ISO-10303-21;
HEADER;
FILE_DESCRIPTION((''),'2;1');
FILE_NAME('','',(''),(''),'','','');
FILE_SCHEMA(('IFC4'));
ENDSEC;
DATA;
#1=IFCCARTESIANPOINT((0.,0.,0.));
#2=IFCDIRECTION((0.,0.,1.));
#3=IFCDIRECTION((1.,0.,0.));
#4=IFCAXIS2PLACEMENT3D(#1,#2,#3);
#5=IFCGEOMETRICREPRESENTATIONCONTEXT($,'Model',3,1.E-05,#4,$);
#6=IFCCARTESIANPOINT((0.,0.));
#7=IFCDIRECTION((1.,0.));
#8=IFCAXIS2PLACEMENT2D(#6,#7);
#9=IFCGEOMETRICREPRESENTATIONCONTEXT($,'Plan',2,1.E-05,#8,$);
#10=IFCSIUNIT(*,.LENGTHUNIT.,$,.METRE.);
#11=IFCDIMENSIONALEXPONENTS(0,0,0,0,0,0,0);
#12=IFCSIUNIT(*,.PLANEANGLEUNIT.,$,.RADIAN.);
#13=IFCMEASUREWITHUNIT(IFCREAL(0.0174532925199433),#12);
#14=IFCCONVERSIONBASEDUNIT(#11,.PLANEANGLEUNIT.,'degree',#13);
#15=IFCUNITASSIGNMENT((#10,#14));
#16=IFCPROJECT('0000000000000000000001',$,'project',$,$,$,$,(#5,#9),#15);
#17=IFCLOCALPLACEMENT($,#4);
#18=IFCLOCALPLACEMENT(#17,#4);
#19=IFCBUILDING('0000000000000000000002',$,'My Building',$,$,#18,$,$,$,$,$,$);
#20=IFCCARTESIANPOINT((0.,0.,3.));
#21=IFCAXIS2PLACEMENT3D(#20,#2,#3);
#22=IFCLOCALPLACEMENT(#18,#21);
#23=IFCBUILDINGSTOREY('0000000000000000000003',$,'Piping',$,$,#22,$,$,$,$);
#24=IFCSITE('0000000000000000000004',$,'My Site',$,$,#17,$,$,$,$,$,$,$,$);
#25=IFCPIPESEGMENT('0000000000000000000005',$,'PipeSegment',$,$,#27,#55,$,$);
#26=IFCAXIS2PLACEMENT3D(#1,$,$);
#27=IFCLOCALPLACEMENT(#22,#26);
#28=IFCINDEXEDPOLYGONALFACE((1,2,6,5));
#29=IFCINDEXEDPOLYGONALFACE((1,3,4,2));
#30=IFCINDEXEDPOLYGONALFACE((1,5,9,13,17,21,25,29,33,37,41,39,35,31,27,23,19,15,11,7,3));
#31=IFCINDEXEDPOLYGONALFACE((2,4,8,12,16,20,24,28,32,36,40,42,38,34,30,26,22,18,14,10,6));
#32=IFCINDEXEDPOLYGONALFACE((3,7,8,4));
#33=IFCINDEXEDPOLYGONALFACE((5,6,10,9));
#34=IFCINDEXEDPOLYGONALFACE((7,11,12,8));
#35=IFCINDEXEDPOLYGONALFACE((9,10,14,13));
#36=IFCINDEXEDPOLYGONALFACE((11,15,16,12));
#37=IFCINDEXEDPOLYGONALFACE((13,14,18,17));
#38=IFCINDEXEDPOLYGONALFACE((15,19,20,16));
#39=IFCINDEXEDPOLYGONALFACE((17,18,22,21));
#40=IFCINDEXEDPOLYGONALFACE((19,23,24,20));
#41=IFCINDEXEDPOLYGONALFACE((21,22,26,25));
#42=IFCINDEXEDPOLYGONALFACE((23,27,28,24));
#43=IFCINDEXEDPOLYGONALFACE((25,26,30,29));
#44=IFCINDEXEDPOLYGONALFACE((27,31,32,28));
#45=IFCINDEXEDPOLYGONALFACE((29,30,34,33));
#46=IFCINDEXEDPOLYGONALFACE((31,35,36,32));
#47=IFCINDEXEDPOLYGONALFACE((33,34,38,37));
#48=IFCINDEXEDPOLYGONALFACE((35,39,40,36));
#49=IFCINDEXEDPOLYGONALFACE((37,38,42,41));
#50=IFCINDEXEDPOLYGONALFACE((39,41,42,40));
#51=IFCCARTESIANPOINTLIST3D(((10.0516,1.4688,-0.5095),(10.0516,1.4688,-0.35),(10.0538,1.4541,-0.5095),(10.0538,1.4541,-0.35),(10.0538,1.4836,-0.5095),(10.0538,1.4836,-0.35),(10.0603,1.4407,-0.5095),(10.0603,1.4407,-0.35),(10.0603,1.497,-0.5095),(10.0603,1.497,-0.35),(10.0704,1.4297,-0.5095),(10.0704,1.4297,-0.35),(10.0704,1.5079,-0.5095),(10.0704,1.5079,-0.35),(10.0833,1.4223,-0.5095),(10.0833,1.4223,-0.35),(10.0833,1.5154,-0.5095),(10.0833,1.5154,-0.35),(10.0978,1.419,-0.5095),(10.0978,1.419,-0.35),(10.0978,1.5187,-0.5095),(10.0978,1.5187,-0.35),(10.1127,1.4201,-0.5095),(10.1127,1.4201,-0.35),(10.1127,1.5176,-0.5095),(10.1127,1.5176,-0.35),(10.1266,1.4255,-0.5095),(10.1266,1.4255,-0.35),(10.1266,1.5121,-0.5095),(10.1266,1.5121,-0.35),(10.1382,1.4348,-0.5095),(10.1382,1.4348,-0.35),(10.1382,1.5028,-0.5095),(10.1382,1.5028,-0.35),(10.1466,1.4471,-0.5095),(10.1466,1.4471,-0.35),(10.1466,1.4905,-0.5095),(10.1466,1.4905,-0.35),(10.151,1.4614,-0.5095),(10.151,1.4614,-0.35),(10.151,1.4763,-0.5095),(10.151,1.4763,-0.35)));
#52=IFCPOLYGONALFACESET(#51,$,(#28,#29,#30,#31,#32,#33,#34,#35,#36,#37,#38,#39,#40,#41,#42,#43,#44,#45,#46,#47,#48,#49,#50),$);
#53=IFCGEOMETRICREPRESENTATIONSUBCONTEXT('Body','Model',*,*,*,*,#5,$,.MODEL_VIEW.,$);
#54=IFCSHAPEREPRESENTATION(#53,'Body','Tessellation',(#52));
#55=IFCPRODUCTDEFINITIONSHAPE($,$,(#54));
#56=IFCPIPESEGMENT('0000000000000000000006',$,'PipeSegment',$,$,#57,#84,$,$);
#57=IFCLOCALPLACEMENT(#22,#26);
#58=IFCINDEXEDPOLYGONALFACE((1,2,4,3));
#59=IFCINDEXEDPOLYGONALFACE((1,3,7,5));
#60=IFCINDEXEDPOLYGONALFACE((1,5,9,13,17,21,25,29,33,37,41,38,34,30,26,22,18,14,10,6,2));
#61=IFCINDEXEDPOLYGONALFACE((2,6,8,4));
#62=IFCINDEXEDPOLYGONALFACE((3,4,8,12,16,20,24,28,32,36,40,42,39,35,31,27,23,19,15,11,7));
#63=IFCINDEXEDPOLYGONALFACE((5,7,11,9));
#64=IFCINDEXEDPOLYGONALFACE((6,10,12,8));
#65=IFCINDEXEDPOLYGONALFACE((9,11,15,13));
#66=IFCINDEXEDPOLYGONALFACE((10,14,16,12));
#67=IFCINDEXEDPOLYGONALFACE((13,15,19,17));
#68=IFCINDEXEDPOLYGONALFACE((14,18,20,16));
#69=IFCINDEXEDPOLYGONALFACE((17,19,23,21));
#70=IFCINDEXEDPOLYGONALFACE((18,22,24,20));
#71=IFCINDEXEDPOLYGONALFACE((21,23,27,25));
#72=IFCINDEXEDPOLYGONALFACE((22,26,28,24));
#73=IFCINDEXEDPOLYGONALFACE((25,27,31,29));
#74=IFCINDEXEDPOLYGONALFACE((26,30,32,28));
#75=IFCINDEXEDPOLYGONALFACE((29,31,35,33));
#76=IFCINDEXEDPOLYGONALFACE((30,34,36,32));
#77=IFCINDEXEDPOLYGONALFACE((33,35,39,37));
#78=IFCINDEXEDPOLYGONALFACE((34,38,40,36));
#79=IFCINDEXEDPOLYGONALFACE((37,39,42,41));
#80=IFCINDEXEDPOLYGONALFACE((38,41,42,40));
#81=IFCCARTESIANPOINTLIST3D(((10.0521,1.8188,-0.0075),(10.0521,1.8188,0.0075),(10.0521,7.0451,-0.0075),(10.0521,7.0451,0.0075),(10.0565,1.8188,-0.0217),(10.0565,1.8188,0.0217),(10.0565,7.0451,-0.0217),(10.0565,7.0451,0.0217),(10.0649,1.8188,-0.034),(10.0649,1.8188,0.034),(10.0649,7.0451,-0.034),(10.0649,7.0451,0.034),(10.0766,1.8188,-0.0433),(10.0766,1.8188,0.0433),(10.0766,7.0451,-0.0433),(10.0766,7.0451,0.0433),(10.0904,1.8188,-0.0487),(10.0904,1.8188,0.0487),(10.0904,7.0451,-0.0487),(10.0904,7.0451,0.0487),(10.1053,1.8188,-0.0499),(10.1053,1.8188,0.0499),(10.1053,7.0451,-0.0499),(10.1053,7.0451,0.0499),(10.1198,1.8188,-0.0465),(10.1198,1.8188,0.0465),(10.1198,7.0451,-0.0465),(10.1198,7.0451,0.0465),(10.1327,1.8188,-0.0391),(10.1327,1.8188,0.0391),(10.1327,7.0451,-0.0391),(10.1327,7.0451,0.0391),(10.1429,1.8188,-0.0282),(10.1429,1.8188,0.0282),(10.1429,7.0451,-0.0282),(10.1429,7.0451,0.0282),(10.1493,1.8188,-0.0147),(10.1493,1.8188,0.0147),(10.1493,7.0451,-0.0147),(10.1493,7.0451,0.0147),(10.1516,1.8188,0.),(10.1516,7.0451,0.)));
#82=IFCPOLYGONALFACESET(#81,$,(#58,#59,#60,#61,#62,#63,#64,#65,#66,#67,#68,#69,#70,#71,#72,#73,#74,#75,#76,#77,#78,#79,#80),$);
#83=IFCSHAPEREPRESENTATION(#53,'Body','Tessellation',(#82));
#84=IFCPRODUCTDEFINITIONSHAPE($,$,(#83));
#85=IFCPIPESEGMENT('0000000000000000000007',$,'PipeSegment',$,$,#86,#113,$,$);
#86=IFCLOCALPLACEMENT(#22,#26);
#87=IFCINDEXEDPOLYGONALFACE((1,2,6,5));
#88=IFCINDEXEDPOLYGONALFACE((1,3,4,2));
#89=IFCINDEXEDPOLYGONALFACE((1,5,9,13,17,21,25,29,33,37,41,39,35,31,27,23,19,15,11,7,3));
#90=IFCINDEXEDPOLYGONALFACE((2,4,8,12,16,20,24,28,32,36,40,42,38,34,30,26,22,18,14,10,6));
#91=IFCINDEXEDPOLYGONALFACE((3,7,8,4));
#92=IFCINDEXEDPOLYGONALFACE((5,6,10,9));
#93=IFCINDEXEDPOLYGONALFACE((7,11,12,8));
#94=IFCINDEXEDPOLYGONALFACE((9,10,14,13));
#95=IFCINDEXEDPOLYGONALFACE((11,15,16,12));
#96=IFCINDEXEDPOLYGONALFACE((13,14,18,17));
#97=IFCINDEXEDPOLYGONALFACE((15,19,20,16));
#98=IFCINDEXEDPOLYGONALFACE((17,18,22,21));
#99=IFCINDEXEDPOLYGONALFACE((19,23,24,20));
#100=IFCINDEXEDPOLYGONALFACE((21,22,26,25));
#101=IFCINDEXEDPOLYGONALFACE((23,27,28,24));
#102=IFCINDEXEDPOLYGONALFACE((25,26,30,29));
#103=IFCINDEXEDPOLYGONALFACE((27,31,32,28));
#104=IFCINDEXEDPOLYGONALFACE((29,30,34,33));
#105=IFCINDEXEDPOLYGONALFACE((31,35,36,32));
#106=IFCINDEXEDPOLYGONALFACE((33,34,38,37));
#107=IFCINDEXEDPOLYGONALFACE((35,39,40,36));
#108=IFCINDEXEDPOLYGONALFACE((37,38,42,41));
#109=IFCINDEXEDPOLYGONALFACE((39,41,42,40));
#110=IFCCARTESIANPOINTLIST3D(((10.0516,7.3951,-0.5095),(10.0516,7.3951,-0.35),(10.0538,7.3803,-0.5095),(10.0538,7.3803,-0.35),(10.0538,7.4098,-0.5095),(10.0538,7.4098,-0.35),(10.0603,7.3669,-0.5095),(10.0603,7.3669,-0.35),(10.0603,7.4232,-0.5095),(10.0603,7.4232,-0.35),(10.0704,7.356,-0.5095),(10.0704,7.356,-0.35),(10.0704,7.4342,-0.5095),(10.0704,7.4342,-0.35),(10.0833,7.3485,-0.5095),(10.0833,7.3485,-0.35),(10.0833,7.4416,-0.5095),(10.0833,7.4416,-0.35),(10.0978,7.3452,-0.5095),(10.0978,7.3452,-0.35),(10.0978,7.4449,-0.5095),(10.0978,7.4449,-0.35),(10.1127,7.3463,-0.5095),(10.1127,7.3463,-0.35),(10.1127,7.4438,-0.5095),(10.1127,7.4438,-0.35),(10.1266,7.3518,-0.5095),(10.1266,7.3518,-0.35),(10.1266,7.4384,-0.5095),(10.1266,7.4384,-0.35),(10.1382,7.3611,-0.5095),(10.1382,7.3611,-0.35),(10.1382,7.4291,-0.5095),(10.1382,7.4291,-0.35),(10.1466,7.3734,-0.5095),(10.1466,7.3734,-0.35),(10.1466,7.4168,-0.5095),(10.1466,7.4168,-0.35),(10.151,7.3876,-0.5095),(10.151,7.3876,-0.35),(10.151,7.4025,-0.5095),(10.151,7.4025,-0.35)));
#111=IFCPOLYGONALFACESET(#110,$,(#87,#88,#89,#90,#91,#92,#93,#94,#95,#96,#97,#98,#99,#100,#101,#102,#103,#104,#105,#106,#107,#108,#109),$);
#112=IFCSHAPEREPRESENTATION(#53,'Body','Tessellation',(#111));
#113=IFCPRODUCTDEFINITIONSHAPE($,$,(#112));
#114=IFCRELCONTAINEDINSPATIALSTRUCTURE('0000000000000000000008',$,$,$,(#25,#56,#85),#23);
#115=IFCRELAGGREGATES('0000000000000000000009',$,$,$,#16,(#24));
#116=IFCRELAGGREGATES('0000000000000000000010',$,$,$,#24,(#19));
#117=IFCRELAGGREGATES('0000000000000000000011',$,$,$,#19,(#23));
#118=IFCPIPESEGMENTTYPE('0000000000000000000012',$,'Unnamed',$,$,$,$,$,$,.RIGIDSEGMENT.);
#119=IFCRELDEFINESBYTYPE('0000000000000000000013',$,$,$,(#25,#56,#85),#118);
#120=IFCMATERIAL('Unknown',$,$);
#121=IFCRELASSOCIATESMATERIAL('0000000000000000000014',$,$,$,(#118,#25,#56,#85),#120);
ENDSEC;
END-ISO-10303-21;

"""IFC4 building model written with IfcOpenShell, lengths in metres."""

from ifc_helpers import new_model, entity, si_unit, converted_unit, frame, origin_with_axes, origin_2d_with_axis, place, context, subcontext, project, spatial, circle, extrude, material, material_profile, profile_set, profile_usage, type_object, element, save


model = new_model("IFC4")

# Units and contexts
model_context = context("Model", 3, precision=1e-05, world=origin_with_axes())
plan_context = context("Plan", 2, precision=1e-05, world=origin_2d_with_axis())
body_context = subcontext(model_context, "Body", "Model", "MODEL_VIEW")
ifc_project = project(units=[si_unit("LENGTHUNIT", "METRE"), converted_unit("PLANEANGLEUNIT", "degree", entity("IfcReal", 0.0174532925199433), si_unit("PLANEANGLEUNIT", "RADIAN"), dimensions=[0, 0, 0, 0, 0, 0, 0])], contexts=[model_context, plan_context])

# Site, building, storey
site_placement = place(None, origin_with_axes())
site = spatial("IfcSite", under=ifc_project, at=site_placement, Name="My Site")
building_placement = place(site_placement, origin_with_axes())
building = spatial("IfcBuilding", under=site, at=building_placement, Name="My Building")
storey_placement = place(building_placement, frame((0.0, 0.0, 3.0), z_axis=(0.0, 0.0, 1.0), x_axis=(1.0, 0.0, 0.0)))
storey = spatial("IfcBuildingStorey", under=building, at=storey_placement, Name="Piping")

# Pipe segments
ifc_material = material(Name="Unknown")
ifc_material_profile = material_profile(ifc_material, circle(Radius=0.05))
ifc_profile_set = profile_set([ifc_material_profile])
pipe_segment_type = type_object("IfcPipeSegmentType", Name="Unnamed", PredefinedType="RIGIDSEGMENT", material=ifc_profile_set)
ifc_profile_usage_1 = profile_usage(ifc_profile_set, cardinal=5)
pipe_segment_1_placement = place(storey_placement, frame((10.1016, 1.4688, -0.35), z_axis=(0.0, 0.0, -1.0), x_axis=(-1.0, 0.0, 0.0)))
element("IfcPipeSegment", 1, at=pipe_segment_1_placement, inside=storey, type_object=pipe_segment_type, material=ifc_profile_usage_1, Name="PipeSegment", context=body_context, shape_type="SweptSolid", body=[
    extrude(circle(Radius=0.05), origin_with_axes(), (0.0, 0.0, 1.0), 0.1595),
])
ifc_profile_usage_2 = profile_usage(ifc_profile_set, cardinal=5)
pipe_segment_2_placement = place(storey_placement, frame((10.1016, 1.8188, 0.0), z_axis=(0.0, 1.0, 0.0), x_axis=(1.0, 0.0, 0.0)))
element("IfcPipeSegment", 2, at=pipe_segment_2_placement, inside=storey, type_object=pipe_segment_type, material=ifc_profile_usage_2, Name="PipeSegment", context=body_context, shape_type="SweptSolid", body=[
    extrude(circle(Radius=0.05), origin_with_axes(), (0.0, 0.0, 1.0), 5.2262),
])
ifc_profile_usage_3 = profile_usage(ifc_profile_set, cardinal=5)
pipe_segment_3_placement = place(storey_placement, frame((10.1016, 7.3951, -0.35), z_axis=(0.0, 0.0, -1.0), x_axis=(-1.0, 0.0, 0.0)))
element("IfcPipeSegment", 3, at=pipe_segment_3_placement, inside=storey, type_object=pipe_segment_type, material=ifc_profile_usage_3, Name="PipeSegment", context=body_context, shape_type="SweptSolid", body=[
    extrude(circle(Radius=0.05), origin_with_axes(), (0.0, 0.0, 1.0), 0.1595),
])

save(model, "model.ifc")
